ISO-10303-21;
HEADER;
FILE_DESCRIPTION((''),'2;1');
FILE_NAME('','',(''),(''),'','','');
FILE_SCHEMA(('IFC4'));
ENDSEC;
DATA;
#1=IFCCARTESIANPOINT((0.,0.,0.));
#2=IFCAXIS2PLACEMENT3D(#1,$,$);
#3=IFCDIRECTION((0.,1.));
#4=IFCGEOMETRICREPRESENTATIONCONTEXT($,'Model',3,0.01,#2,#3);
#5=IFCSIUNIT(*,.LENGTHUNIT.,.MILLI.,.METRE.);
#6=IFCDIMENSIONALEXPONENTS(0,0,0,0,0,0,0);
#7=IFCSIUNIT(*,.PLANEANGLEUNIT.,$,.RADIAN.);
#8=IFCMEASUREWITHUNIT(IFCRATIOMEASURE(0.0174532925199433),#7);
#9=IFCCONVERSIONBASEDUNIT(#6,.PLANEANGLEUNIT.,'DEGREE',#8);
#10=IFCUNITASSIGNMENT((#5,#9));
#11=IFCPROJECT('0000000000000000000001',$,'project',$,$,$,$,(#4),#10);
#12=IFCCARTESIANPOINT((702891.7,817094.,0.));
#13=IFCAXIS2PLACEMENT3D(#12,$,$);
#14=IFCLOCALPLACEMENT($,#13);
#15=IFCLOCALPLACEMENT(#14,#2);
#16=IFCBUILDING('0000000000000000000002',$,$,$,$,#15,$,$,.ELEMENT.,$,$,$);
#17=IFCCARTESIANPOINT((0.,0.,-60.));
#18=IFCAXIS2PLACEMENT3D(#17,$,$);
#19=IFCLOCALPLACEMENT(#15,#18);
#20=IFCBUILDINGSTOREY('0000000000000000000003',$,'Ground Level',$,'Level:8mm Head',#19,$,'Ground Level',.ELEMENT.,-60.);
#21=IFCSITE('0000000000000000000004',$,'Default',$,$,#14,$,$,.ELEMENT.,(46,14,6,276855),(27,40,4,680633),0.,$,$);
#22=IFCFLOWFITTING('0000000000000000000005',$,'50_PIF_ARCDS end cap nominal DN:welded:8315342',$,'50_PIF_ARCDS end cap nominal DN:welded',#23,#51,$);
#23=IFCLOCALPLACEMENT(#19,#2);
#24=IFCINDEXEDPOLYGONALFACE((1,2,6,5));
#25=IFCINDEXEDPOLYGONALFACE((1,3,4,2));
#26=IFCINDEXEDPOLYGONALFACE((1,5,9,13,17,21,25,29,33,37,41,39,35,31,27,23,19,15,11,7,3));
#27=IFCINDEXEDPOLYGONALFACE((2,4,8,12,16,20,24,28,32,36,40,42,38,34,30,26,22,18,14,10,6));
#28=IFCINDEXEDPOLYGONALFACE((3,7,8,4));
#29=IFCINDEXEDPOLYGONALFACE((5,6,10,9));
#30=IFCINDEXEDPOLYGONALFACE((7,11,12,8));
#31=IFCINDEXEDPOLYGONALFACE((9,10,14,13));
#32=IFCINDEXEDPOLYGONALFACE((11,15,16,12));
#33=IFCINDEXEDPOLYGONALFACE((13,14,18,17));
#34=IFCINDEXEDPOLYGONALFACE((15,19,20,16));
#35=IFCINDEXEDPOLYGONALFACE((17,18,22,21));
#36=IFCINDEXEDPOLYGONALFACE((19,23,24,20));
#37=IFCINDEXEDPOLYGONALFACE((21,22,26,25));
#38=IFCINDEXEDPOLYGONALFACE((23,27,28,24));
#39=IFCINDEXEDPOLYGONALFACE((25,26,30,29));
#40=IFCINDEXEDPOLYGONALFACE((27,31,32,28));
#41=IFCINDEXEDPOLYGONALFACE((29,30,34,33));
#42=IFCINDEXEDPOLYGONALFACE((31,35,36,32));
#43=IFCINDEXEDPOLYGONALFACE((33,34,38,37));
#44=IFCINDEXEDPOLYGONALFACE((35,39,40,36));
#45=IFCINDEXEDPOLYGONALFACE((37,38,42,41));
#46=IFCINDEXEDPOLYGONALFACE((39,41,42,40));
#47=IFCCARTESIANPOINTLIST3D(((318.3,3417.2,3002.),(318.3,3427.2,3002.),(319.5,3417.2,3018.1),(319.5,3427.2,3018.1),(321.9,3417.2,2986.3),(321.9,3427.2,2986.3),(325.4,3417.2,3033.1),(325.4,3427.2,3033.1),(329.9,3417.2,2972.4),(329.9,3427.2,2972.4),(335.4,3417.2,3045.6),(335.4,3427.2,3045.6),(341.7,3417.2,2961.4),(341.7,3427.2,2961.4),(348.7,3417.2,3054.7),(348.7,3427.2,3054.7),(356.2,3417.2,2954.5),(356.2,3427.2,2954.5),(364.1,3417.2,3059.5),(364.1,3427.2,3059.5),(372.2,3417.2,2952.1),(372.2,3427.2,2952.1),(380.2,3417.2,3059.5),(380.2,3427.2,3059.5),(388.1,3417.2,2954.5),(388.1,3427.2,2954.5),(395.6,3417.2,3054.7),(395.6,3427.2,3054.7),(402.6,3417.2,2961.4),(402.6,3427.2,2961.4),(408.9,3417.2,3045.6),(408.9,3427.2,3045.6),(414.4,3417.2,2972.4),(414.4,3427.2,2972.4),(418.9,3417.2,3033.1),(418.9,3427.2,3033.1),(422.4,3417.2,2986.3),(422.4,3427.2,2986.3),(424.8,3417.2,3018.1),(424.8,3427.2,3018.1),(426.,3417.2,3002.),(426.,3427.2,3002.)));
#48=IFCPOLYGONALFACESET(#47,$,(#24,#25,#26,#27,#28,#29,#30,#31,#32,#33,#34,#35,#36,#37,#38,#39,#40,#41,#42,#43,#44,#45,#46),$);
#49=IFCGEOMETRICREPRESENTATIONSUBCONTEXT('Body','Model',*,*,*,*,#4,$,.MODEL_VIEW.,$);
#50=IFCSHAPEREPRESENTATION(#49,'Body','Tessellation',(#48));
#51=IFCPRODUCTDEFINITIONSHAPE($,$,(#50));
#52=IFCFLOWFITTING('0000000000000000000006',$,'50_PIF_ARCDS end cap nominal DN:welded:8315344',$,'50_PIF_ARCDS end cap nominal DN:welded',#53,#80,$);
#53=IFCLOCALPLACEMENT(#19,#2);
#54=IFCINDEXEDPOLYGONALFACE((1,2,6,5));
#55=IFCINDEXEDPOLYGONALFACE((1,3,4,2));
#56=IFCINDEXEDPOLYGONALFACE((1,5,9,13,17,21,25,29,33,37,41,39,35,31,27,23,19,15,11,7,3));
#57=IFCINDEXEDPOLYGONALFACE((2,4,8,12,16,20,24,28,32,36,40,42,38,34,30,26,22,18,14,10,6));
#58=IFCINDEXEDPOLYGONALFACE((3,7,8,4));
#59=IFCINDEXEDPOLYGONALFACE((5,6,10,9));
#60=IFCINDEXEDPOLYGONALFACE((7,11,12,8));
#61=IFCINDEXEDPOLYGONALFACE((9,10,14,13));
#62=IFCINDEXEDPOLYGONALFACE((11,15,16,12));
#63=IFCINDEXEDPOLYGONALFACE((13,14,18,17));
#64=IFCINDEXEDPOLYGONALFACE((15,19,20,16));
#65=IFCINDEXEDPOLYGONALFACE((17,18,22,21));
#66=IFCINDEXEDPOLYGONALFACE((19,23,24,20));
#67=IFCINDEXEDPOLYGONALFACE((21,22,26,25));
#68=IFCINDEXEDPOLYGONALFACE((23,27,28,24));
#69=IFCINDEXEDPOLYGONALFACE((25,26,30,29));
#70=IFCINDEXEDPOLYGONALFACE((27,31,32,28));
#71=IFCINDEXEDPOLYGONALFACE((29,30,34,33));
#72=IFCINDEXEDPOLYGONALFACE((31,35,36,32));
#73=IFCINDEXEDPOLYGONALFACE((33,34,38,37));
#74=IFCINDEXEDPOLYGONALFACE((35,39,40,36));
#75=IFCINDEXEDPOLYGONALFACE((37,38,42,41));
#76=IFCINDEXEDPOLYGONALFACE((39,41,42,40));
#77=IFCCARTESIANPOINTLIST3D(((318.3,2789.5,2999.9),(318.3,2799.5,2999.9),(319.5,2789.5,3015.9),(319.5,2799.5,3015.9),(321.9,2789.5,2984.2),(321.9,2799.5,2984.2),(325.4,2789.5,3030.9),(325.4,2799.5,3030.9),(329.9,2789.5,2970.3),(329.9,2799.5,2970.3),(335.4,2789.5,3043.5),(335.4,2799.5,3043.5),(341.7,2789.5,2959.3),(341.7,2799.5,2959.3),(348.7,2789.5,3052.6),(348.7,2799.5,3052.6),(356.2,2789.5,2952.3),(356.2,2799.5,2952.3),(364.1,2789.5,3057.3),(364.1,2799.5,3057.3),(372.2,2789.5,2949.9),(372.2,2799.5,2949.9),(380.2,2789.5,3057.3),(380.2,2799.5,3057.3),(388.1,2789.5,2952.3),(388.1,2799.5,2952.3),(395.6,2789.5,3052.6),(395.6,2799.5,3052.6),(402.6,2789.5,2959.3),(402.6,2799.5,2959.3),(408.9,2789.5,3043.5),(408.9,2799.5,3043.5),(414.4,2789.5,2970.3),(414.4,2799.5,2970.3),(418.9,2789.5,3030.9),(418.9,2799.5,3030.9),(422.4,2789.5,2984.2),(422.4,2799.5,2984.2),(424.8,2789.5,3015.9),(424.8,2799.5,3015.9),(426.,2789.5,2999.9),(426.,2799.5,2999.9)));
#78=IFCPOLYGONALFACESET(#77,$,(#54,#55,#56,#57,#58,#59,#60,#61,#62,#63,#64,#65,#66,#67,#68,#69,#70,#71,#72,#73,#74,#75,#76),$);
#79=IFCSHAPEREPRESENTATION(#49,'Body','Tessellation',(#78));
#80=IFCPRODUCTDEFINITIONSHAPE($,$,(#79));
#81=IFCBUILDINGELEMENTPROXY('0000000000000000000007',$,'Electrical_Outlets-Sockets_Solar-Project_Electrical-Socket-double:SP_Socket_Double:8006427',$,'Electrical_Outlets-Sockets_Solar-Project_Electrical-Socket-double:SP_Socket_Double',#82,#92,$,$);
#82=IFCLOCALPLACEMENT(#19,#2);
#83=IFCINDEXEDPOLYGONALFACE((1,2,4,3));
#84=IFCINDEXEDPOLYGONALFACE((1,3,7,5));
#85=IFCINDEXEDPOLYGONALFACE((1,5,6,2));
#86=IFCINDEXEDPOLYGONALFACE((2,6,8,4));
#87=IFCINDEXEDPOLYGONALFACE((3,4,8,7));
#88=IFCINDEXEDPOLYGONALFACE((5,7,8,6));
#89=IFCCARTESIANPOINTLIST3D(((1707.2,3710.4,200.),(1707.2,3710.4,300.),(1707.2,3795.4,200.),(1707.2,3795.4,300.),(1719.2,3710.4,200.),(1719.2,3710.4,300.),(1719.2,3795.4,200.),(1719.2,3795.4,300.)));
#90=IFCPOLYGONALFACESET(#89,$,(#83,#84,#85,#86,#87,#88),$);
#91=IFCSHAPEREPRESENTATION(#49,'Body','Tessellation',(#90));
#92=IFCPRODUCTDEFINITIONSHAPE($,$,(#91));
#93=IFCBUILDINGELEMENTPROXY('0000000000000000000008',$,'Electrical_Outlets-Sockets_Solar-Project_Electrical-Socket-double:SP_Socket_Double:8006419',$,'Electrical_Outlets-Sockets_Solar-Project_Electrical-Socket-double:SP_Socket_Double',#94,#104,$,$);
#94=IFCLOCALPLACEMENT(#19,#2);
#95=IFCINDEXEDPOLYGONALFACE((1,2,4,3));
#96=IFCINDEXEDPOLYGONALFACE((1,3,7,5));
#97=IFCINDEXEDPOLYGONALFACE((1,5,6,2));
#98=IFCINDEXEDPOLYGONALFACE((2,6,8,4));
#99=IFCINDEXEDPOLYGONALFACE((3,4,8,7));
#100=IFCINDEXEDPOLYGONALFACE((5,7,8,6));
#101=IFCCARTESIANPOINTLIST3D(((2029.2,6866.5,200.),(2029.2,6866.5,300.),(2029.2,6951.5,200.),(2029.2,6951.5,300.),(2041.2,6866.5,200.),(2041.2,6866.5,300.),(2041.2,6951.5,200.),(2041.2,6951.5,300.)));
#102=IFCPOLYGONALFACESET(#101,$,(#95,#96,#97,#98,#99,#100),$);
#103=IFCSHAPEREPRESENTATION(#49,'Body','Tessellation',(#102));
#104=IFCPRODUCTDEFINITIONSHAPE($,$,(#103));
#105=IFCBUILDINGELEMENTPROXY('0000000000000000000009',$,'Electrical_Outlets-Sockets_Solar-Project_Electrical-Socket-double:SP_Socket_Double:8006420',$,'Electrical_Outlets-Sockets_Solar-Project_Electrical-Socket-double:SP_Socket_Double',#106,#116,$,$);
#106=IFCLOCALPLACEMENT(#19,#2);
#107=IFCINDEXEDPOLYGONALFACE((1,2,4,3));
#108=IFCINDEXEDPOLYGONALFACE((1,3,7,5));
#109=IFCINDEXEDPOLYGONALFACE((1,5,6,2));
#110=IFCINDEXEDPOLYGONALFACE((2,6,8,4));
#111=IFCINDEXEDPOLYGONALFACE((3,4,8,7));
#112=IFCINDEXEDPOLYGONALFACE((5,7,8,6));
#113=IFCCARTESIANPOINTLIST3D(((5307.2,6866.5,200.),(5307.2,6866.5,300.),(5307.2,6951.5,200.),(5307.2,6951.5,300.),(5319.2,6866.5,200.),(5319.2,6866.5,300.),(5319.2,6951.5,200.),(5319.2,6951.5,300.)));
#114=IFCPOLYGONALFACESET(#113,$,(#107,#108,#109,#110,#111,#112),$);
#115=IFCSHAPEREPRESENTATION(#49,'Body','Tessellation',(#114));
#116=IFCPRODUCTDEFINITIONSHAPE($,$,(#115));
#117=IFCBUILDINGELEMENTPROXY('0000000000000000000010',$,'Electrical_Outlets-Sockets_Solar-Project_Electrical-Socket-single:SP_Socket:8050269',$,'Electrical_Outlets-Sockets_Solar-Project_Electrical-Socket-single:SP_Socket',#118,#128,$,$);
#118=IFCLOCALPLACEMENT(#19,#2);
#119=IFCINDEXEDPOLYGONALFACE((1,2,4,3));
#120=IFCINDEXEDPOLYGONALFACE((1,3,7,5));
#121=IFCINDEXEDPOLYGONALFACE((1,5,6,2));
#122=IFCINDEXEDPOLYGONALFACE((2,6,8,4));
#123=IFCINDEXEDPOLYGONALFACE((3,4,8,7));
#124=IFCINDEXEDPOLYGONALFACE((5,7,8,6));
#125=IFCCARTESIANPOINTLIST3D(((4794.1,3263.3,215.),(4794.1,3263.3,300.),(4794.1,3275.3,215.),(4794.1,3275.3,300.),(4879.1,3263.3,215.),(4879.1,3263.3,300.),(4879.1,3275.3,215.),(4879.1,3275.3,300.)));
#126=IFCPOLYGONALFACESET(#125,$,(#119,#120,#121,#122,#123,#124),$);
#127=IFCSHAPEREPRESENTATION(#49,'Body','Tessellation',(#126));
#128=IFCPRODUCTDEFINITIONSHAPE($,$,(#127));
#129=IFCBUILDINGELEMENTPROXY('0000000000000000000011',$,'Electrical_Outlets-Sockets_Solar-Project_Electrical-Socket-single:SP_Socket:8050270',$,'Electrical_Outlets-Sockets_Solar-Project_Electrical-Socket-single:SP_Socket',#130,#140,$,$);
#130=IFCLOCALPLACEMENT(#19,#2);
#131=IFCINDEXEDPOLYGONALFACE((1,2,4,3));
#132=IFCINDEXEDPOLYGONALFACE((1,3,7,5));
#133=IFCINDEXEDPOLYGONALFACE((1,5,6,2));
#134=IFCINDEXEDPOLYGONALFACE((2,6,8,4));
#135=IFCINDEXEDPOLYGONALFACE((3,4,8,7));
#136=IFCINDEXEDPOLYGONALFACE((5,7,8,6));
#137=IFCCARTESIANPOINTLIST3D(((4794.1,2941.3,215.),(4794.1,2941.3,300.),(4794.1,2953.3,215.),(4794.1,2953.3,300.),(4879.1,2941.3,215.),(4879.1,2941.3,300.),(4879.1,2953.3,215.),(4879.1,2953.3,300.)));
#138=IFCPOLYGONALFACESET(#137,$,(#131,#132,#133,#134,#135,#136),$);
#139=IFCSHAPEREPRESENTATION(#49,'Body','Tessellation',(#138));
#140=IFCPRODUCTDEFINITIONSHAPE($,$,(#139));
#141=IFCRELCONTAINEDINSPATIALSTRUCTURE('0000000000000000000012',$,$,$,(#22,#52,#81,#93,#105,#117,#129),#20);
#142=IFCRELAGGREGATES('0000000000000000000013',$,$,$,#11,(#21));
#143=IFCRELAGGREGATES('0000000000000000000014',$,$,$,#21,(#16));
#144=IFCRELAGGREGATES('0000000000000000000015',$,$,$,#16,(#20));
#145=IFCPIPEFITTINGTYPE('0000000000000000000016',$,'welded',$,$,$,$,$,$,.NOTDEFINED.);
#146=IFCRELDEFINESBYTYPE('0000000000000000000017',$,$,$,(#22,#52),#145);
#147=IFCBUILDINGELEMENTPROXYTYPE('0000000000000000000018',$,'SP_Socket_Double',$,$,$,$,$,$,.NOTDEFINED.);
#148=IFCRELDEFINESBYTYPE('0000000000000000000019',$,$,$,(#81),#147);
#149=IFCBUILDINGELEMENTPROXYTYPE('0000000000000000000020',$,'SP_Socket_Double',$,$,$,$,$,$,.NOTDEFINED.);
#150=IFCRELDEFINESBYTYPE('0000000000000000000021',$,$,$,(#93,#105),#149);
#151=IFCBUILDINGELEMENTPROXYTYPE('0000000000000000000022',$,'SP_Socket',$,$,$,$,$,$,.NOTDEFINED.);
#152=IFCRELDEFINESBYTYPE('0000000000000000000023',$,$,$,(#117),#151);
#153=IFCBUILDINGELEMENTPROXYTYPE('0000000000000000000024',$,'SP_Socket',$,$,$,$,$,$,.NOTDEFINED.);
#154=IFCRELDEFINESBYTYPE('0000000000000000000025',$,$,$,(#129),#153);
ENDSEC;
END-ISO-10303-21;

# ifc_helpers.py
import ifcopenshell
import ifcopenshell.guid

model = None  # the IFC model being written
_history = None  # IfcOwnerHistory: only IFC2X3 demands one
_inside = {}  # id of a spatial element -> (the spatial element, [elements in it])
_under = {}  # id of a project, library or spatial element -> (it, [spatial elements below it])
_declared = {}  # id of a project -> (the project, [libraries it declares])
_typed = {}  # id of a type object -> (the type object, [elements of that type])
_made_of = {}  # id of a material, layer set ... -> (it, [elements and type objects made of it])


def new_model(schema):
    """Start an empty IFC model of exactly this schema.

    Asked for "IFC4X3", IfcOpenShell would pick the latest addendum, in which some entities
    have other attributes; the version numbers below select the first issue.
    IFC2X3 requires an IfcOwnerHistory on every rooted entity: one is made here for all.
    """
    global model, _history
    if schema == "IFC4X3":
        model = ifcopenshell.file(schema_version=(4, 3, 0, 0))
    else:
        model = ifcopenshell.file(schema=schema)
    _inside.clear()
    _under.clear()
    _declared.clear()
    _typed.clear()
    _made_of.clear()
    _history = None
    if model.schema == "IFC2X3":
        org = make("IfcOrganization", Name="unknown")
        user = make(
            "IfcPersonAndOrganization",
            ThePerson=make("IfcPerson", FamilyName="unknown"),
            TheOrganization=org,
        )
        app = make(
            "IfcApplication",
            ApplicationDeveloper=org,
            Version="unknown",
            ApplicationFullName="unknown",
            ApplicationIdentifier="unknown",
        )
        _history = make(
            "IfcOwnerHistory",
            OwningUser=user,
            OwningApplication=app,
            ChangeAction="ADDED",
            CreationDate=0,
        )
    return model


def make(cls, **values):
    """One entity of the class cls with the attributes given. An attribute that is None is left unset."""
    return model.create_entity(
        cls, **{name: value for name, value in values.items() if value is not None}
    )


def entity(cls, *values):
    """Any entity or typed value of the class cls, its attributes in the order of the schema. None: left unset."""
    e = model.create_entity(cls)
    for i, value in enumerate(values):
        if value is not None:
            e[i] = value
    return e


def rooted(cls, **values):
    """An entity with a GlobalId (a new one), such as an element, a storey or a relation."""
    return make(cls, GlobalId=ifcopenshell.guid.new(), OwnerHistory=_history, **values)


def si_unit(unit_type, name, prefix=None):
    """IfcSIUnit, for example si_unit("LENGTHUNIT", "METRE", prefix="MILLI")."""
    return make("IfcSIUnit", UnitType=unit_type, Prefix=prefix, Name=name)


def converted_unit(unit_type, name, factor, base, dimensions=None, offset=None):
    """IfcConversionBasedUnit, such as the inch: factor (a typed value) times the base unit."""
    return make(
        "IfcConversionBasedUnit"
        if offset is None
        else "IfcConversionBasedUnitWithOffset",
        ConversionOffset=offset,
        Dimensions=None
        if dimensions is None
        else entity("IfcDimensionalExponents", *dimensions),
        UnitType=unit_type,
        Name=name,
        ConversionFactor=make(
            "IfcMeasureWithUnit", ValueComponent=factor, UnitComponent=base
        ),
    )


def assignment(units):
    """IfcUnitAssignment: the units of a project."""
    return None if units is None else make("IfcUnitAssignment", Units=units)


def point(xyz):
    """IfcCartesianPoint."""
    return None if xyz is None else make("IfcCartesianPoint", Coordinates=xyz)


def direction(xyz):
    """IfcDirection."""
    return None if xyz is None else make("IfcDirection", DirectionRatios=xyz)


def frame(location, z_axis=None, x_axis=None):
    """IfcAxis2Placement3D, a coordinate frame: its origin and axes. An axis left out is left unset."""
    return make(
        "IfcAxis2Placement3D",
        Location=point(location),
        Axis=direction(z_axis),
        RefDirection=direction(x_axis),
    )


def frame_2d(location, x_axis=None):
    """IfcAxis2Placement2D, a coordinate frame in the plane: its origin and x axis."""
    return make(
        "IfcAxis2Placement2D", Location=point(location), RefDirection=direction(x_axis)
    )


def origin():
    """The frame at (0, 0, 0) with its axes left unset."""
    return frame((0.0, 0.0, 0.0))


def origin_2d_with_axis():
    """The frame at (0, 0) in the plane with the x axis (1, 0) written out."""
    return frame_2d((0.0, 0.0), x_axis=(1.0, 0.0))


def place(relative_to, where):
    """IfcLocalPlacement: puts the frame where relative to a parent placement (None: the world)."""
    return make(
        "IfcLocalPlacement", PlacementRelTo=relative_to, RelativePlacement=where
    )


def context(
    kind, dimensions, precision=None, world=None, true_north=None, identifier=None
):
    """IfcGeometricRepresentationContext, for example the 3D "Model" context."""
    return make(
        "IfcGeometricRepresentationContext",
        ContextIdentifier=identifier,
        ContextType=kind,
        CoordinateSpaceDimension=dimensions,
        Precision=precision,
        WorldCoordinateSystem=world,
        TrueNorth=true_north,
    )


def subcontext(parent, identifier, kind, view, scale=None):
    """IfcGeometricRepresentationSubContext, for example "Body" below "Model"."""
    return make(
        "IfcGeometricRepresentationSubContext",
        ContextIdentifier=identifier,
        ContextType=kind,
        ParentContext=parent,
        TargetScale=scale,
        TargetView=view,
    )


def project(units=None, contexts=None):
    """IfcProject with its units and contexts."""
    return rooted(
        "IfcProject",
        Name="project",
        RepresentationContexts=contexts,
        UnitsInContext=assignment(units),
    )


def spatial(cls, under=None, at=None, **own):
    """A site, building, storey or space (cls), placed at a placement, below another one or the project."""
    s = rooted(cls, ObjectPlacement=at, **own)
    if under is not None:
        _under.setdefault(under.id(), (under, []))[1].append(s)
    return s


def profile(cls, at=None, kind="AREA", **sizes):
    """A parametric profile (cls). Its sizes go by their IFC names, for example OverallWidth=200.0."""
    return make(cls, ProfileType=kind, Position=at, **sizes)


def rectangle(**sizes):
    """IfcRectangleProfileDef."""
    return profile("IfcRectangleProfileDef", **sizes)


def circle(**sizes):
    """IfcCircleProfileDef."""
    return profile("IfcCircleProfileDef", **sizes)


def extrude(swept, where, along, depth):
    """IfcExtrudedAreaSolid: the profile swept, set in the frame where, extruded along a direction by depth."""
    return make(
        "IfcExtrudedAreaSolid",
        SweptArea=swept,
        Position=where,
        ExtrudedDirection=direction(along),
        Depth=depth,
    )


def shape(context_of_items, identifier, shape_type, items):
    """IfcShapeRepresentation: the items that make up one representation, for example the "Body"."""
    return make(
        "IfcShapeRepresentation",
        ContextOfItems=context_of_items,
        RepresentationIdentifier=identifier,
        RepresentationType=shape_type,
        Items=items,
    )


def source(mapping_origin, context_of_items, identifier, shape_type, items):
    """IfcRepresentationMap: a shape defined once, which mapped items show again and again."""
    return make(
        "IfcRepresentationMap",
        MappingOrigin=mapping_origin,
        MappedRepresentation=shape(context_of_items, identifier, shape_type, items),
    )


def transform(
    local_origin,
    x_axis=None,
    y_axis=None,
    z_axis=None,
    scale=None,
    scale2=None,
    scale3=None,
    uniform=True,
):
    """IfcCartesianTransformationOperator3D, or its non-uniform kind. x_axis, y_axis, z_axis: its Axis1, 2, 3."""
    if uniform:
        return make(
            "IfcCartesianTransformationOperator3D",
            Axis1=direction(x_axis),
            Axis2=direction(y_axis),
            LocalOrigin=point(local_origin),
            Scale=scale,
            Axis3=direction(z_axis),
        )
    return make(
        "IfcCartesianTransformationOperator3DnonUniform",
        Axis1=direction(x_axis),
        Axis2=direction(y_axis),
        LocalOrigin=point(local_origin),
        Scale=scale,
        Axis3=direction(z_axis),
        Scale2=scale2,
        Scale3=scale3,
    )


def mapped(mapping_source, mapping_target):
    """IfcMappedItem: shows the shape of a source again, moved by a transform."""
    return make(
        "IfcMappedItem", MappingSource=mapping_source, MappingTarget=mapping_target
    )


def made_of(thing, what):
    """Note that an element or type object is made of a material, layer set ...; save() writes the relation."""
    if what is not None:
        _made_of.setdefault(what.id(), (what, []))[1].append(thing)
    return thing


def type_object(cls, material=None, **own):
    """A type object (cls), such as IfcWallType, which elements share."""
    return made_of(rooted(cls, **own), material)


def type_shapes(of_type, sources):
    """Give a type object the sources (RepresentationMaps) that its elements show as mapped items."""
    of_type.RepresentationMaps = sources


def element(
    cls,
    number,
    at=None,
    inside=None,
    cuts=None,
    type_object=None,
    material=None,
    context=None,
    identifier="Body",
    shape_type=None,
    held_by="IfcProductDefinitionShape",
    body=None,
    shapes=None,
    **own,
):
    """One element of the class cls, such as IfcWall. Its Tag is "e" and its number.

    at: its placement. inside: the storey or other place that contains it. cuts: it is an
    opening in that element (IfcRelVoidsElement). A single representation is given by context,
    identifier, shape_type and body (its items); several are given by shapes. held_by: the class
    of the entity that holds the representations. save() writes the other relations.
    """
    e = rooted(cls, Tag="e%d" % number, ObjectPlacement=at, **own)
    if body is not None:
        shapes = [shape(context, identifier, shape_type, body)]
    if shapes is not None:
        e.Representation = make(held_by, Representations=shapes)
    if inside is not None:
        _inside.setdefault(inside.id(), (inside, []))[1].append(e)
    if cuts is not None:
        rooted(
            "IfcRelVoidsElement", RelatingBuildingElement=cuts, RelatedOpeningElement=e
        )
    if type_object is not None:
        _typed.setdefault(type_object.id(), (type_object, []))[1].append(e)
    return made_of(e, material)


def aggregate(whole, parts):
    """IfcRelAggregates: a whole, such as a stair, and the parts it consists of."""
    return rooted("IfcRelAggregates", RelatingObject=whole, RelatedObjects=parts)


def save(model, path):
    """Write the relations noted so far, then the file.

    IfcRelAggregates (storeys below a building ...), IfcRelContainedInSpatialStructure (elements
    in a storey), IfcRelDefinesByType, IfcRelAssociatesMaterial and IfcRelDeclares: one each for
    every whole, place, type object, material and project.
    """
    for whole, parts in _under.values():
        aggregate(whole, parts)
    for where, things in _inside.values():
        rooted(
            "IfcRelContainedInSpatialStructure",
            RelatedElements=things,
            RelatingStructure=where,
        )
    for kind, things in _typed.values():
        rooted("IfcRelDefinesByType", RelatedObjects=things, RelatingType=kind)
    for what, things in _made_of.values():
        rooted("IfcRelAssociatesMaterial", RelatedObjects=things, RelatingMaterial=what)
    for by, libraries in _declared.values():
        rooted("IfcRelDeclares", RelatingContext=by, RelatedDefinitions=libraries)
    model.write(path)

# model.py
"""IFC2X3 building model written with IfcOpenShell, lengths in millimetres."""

from ifc_helpers import new_model, entity, si_unit, converted_unit, direction, frame, frame_2d, origin, origin_2d_with_axis, place, context, subcontext, project, spatial, rectangle, circle, extrude, source, transform, mapped, type_object, type_shapes, element, save


model = new_model("IFC2X3")

# Units and contexts
model_context = context("Model", 3, precision=0.01, world=origin(), true_north=direction((0.0, 1.0)))
body_context = subcontext(model_context, "Body", "Model", "MODEL_VIEW")
ifc_project = project(units=[si_unit("LENGTHUNIT", "METRE", prefix="MILLI"), converted_unit("PLANEANGLEUNIT", "DEGREE", entity("IfcRatioMeasure", 0.0174532925199433), si_unit("PLANEANGLEUNIT", "RADIAN"), dimensions=[0, 0, 0, 0, 0, 0, 0])], contexts=[model_context])

# Site, building, storey
site_placement = place(None, frame((702891.7, 817094.0, 0.0)))
site = spatial("IfcSite", under=ifc_project, at=site_placement, Name="Default", CompositionType="ELEMENT", RefLatitude=(46, 14, 6, 276855), RefLongitude=(27, 40, 4, 680633), RefElevation=0.0)
building_placement = place(site_placement, origin())
building = spatial("IfcBuilding", under=site, at=building_placement, CompositionType="ELEMENT")
storey_placement = place(building_placement, frame((0.0, 0.0, -60.0)))
storey = spatial("IfcBuildingStorey", under=building, at=storey_placement, Name="Ground Level", ObjectType="Level:8mm Head", LongName="Ground Level", CompositionType="ELEMENT", Elevation=-60.0)

# Flow fittings
pipe_fitting_type = type_object("IfcPipeFittingType", Name="welded", PredefinedType="NOTDEFINED")
shared_shape_1 = source(origin(), body_context, "Body", "SweptSolid", [
    extrude(circle(Radius=54.0, at=frame_2d((0.0, 0.0), x_axis=(1.0, 0.0))), frame((0.0, 0.0, 0.0), z_axis=(1.0, 0.0, 0.0), x_axis=(0.0, 1.0, 0.0)), (0.0, 0.0, 1.0), 10.0),
])
type_shapes(pipe_fitting_type, [shared_shape_1])
for number, where, z_axis, x_axis, name in (
    (1, (372.2, 3417.2, 3006.1), (-1.0, 0.0, 0.0), (0.0, 1.0, 0.0), "50_PIF_ARCDS end cap nominal DN:welded:8315342"),
    (2, (372.2, 2799.5, 3003.9), (1.0, 0.0, 0.0), (0.0, -1.0, 0.0), "50_PIF_ARCDS end cap nominal DN:welded:8315344"),
):
    element("IfcFlowFitting", number, at=place(storey_placement, frame(where, z_axis=z_axis, x_axis=x_axis)), inside=storey, type_object=pipe_fitting_type, Name=name, ObjectType="50_PIF_ARCDS end cap nominal DN:welded", context=body_context, shape_type="MappedRepresentation", body=[
        mapped(shared_shape_1, transform((0.0, 0.0, 0.0), scale=1.0)),
    ])

# Building element proxies
building_element_proxy_type_1 = type_object("IfcBuildingElementProxyType", Name="SP_Socket_Double", PredefinedType="NOTDEFINED")
shared_shape_2 = source(origin(), body_context, "Body", "SweptSolid", [
    extrude(rectangle(XDim=85.0, YDim=12.0, at=origin_2d_with_axis()), frame((0.0, 6.0, -100.0), z_axis=(0.0, 0.0, 1.0), x_axis=(-1.0, 0.0, 0.0)), (0.0, 0.0, 1.0), 100.0),
])
type_shapes(building_element_proxy_type_1, [shared_shape_2])
proxy_1_placement = place(storey_placement, frame((1719.2, 3752.9, 300.0), z_axis=(0.0, 0.0, 1.0), x_axis=(0.0, 1.0, 0.0)))
element("IfcBuildingElementProxy", 3, at=proxy_1_placement, inside=storey, type_object=building_element_proxy_type_1, Name="Electrical_Outlets-Sockets_Solar-Project_Electrical-Socket-double:SP_Socket_Double:8006427", ObjectType="Electrical_Outlets-Sockets_Solar-Project_Electrical-Socket-double:SP_Socket_Double", context=body_context, shape_type="MappedRepresentation", body=[
    mapped(shared_shape_2, transform((0.0, 0.0, 0.0), scale=1.0)),
])
building_element_proxy_type_2 = type_object("IfcBuildingElementProxyType", Name="SP_Socket_Double", PredefinedType="NOTDEFINED")
shared_shape_3 = source(origin(), body_context, "Body", "SweptSolid", [
    extrude(rectangle(XDim=12.0, YDim=85.0, at=origin_2d_with_axis()), frame((0.0, -6.0, -100.0), z_axis=(0.0, 0.0, 1.0), x_axis=(0.0, 1.0, 0.0)), (0.0, 0.0, 1.0), 100.0),
])
type_shapes(building_element_proxy_type_2, [shared_shape_3])
for number, where, z_axis, x_axis, name in (
    (4, (2029.2, 6909.0, 300.0), (0.0, 0.0, 1.0), (0.0, 1.0, 0.0), "Electrical_Outlets-Sockets_Solar-Project_Electrical-Socket-double:SP_Socket_Double:8006419"),
    (5, (5319.2, 6909.0, 300.0), (0.0, 0.0, 1.0), (0.0, -1.0, 0.0), "Electrical_Outlets-Sockets_Solar-Project_Electrical-Socket-double:SP_Socket_Double:8006420"),
):
    element("IfcBuildingElementProxy", number, at=place(storey_placement, frame(where, z_axis=z_axis, x_axis=x_axis)), inside=storey, type_object=building_element_proxy_type_2, Name=name, ObjectType="Electrical_Outlets-Sockets_Solar-Project_Electrical-Socket-double:SP_Socket_Double", context=body_context, shape_type="MappedRepresentation", body=[
        mapped(shared_shape_3, transform((0.0, 0.0, 0.0), scale=1.0)),
    ])
building_element_proxy_type_3 = type_object("IfcBuildingElementProxyType", Name="SP_Socket", PredefinedType="NOTDEFINED")
shared_shape_4 = source(origin(), body_context, "Body", "SweptSolid", [
    extrude(rectangle(XDim=12.0, YDim=85.0, at=origin_2d_with_axis()), frame((0.0, -6.0, -85.0), z_axis=(0.0, 0.0, 1.0), x_axis=(0.0, 1.0, 0.0)), (0.0, 0.0, 1.0), 85.0),
])
type_shapes(building_element_proxy_type_3, [shared_shape_4])
proxy_2_placement = place(storey_placement, frame((4836.6, 3263.3, 300.0), z_axis=(0.0, 0.0, 1.0), x_axis=(-1.0, 0.0, 0.0)))
element("IfcBuildingElementProxy", 6, at=proxy_2_placement, inside=storey, type_object=building_element_proxy_type_3, Name="Electrical_Outlets-Sockets_Solar-Project_Electrical-Socket-single:SP_Socket:8050269", ObjectType="Electrical_Outlets-Sockets_Solar-Project_Electrical-Socket-single:SP_Socket", context=body_context, shape_type="MappedRepresentation", body=[
    mapped(shared_shape_4, transform((0.0, 0.0, 0.0), scale=1.0)),
])
building_element_proxy_type_4 = type_object("IfcBuildingElementProxyType", Name="SP_Socket", PredefinedType="NOTDEFINED")
shared_shape_5 = source(origin(), body_context, "Body", "SweptSolid", [
    extrude(rectangle(XDim=85.0, YDim=12.0, at=origin_2d_with_axis()), frame((0.0, 6.0, -85.0), z_axis=(0.0, 0.0, 1.0), x_axis=(-1.0, 0.0, 0.0)), (0.0, 0.0, 1.0), 85.0),
])
type_shapes(building_element_proxy_type_4, [shared_shape_5])
proxy_3_placement = place(storey_placement, frame((4836.6, 2953.3, 300.0), z_axis=(0.0, 0.0, 1.0), x_axis=(-1.0, 0.0, 0.0)))
element("IfcBuildingElementProxy", 7, at=proxy_3_placement, inside=storey, type_object=building_element_proxy_type_4, Name="Electrical_Outlets-Sockets_Solar-Project_Electrical-Socket-single:SP_Socket:8050270", ObjectType="Electrical_Outlets-Sockets_Solar-Project_Electrical-Socket-single:SP_Socket", context=body_context, shape_type="MappedRepresentation", body=[
    mapped(shared_shape_5, transform((0.0, 0.0, 0.0), scale=1.0)),
])

save(model, "model.ifc")
